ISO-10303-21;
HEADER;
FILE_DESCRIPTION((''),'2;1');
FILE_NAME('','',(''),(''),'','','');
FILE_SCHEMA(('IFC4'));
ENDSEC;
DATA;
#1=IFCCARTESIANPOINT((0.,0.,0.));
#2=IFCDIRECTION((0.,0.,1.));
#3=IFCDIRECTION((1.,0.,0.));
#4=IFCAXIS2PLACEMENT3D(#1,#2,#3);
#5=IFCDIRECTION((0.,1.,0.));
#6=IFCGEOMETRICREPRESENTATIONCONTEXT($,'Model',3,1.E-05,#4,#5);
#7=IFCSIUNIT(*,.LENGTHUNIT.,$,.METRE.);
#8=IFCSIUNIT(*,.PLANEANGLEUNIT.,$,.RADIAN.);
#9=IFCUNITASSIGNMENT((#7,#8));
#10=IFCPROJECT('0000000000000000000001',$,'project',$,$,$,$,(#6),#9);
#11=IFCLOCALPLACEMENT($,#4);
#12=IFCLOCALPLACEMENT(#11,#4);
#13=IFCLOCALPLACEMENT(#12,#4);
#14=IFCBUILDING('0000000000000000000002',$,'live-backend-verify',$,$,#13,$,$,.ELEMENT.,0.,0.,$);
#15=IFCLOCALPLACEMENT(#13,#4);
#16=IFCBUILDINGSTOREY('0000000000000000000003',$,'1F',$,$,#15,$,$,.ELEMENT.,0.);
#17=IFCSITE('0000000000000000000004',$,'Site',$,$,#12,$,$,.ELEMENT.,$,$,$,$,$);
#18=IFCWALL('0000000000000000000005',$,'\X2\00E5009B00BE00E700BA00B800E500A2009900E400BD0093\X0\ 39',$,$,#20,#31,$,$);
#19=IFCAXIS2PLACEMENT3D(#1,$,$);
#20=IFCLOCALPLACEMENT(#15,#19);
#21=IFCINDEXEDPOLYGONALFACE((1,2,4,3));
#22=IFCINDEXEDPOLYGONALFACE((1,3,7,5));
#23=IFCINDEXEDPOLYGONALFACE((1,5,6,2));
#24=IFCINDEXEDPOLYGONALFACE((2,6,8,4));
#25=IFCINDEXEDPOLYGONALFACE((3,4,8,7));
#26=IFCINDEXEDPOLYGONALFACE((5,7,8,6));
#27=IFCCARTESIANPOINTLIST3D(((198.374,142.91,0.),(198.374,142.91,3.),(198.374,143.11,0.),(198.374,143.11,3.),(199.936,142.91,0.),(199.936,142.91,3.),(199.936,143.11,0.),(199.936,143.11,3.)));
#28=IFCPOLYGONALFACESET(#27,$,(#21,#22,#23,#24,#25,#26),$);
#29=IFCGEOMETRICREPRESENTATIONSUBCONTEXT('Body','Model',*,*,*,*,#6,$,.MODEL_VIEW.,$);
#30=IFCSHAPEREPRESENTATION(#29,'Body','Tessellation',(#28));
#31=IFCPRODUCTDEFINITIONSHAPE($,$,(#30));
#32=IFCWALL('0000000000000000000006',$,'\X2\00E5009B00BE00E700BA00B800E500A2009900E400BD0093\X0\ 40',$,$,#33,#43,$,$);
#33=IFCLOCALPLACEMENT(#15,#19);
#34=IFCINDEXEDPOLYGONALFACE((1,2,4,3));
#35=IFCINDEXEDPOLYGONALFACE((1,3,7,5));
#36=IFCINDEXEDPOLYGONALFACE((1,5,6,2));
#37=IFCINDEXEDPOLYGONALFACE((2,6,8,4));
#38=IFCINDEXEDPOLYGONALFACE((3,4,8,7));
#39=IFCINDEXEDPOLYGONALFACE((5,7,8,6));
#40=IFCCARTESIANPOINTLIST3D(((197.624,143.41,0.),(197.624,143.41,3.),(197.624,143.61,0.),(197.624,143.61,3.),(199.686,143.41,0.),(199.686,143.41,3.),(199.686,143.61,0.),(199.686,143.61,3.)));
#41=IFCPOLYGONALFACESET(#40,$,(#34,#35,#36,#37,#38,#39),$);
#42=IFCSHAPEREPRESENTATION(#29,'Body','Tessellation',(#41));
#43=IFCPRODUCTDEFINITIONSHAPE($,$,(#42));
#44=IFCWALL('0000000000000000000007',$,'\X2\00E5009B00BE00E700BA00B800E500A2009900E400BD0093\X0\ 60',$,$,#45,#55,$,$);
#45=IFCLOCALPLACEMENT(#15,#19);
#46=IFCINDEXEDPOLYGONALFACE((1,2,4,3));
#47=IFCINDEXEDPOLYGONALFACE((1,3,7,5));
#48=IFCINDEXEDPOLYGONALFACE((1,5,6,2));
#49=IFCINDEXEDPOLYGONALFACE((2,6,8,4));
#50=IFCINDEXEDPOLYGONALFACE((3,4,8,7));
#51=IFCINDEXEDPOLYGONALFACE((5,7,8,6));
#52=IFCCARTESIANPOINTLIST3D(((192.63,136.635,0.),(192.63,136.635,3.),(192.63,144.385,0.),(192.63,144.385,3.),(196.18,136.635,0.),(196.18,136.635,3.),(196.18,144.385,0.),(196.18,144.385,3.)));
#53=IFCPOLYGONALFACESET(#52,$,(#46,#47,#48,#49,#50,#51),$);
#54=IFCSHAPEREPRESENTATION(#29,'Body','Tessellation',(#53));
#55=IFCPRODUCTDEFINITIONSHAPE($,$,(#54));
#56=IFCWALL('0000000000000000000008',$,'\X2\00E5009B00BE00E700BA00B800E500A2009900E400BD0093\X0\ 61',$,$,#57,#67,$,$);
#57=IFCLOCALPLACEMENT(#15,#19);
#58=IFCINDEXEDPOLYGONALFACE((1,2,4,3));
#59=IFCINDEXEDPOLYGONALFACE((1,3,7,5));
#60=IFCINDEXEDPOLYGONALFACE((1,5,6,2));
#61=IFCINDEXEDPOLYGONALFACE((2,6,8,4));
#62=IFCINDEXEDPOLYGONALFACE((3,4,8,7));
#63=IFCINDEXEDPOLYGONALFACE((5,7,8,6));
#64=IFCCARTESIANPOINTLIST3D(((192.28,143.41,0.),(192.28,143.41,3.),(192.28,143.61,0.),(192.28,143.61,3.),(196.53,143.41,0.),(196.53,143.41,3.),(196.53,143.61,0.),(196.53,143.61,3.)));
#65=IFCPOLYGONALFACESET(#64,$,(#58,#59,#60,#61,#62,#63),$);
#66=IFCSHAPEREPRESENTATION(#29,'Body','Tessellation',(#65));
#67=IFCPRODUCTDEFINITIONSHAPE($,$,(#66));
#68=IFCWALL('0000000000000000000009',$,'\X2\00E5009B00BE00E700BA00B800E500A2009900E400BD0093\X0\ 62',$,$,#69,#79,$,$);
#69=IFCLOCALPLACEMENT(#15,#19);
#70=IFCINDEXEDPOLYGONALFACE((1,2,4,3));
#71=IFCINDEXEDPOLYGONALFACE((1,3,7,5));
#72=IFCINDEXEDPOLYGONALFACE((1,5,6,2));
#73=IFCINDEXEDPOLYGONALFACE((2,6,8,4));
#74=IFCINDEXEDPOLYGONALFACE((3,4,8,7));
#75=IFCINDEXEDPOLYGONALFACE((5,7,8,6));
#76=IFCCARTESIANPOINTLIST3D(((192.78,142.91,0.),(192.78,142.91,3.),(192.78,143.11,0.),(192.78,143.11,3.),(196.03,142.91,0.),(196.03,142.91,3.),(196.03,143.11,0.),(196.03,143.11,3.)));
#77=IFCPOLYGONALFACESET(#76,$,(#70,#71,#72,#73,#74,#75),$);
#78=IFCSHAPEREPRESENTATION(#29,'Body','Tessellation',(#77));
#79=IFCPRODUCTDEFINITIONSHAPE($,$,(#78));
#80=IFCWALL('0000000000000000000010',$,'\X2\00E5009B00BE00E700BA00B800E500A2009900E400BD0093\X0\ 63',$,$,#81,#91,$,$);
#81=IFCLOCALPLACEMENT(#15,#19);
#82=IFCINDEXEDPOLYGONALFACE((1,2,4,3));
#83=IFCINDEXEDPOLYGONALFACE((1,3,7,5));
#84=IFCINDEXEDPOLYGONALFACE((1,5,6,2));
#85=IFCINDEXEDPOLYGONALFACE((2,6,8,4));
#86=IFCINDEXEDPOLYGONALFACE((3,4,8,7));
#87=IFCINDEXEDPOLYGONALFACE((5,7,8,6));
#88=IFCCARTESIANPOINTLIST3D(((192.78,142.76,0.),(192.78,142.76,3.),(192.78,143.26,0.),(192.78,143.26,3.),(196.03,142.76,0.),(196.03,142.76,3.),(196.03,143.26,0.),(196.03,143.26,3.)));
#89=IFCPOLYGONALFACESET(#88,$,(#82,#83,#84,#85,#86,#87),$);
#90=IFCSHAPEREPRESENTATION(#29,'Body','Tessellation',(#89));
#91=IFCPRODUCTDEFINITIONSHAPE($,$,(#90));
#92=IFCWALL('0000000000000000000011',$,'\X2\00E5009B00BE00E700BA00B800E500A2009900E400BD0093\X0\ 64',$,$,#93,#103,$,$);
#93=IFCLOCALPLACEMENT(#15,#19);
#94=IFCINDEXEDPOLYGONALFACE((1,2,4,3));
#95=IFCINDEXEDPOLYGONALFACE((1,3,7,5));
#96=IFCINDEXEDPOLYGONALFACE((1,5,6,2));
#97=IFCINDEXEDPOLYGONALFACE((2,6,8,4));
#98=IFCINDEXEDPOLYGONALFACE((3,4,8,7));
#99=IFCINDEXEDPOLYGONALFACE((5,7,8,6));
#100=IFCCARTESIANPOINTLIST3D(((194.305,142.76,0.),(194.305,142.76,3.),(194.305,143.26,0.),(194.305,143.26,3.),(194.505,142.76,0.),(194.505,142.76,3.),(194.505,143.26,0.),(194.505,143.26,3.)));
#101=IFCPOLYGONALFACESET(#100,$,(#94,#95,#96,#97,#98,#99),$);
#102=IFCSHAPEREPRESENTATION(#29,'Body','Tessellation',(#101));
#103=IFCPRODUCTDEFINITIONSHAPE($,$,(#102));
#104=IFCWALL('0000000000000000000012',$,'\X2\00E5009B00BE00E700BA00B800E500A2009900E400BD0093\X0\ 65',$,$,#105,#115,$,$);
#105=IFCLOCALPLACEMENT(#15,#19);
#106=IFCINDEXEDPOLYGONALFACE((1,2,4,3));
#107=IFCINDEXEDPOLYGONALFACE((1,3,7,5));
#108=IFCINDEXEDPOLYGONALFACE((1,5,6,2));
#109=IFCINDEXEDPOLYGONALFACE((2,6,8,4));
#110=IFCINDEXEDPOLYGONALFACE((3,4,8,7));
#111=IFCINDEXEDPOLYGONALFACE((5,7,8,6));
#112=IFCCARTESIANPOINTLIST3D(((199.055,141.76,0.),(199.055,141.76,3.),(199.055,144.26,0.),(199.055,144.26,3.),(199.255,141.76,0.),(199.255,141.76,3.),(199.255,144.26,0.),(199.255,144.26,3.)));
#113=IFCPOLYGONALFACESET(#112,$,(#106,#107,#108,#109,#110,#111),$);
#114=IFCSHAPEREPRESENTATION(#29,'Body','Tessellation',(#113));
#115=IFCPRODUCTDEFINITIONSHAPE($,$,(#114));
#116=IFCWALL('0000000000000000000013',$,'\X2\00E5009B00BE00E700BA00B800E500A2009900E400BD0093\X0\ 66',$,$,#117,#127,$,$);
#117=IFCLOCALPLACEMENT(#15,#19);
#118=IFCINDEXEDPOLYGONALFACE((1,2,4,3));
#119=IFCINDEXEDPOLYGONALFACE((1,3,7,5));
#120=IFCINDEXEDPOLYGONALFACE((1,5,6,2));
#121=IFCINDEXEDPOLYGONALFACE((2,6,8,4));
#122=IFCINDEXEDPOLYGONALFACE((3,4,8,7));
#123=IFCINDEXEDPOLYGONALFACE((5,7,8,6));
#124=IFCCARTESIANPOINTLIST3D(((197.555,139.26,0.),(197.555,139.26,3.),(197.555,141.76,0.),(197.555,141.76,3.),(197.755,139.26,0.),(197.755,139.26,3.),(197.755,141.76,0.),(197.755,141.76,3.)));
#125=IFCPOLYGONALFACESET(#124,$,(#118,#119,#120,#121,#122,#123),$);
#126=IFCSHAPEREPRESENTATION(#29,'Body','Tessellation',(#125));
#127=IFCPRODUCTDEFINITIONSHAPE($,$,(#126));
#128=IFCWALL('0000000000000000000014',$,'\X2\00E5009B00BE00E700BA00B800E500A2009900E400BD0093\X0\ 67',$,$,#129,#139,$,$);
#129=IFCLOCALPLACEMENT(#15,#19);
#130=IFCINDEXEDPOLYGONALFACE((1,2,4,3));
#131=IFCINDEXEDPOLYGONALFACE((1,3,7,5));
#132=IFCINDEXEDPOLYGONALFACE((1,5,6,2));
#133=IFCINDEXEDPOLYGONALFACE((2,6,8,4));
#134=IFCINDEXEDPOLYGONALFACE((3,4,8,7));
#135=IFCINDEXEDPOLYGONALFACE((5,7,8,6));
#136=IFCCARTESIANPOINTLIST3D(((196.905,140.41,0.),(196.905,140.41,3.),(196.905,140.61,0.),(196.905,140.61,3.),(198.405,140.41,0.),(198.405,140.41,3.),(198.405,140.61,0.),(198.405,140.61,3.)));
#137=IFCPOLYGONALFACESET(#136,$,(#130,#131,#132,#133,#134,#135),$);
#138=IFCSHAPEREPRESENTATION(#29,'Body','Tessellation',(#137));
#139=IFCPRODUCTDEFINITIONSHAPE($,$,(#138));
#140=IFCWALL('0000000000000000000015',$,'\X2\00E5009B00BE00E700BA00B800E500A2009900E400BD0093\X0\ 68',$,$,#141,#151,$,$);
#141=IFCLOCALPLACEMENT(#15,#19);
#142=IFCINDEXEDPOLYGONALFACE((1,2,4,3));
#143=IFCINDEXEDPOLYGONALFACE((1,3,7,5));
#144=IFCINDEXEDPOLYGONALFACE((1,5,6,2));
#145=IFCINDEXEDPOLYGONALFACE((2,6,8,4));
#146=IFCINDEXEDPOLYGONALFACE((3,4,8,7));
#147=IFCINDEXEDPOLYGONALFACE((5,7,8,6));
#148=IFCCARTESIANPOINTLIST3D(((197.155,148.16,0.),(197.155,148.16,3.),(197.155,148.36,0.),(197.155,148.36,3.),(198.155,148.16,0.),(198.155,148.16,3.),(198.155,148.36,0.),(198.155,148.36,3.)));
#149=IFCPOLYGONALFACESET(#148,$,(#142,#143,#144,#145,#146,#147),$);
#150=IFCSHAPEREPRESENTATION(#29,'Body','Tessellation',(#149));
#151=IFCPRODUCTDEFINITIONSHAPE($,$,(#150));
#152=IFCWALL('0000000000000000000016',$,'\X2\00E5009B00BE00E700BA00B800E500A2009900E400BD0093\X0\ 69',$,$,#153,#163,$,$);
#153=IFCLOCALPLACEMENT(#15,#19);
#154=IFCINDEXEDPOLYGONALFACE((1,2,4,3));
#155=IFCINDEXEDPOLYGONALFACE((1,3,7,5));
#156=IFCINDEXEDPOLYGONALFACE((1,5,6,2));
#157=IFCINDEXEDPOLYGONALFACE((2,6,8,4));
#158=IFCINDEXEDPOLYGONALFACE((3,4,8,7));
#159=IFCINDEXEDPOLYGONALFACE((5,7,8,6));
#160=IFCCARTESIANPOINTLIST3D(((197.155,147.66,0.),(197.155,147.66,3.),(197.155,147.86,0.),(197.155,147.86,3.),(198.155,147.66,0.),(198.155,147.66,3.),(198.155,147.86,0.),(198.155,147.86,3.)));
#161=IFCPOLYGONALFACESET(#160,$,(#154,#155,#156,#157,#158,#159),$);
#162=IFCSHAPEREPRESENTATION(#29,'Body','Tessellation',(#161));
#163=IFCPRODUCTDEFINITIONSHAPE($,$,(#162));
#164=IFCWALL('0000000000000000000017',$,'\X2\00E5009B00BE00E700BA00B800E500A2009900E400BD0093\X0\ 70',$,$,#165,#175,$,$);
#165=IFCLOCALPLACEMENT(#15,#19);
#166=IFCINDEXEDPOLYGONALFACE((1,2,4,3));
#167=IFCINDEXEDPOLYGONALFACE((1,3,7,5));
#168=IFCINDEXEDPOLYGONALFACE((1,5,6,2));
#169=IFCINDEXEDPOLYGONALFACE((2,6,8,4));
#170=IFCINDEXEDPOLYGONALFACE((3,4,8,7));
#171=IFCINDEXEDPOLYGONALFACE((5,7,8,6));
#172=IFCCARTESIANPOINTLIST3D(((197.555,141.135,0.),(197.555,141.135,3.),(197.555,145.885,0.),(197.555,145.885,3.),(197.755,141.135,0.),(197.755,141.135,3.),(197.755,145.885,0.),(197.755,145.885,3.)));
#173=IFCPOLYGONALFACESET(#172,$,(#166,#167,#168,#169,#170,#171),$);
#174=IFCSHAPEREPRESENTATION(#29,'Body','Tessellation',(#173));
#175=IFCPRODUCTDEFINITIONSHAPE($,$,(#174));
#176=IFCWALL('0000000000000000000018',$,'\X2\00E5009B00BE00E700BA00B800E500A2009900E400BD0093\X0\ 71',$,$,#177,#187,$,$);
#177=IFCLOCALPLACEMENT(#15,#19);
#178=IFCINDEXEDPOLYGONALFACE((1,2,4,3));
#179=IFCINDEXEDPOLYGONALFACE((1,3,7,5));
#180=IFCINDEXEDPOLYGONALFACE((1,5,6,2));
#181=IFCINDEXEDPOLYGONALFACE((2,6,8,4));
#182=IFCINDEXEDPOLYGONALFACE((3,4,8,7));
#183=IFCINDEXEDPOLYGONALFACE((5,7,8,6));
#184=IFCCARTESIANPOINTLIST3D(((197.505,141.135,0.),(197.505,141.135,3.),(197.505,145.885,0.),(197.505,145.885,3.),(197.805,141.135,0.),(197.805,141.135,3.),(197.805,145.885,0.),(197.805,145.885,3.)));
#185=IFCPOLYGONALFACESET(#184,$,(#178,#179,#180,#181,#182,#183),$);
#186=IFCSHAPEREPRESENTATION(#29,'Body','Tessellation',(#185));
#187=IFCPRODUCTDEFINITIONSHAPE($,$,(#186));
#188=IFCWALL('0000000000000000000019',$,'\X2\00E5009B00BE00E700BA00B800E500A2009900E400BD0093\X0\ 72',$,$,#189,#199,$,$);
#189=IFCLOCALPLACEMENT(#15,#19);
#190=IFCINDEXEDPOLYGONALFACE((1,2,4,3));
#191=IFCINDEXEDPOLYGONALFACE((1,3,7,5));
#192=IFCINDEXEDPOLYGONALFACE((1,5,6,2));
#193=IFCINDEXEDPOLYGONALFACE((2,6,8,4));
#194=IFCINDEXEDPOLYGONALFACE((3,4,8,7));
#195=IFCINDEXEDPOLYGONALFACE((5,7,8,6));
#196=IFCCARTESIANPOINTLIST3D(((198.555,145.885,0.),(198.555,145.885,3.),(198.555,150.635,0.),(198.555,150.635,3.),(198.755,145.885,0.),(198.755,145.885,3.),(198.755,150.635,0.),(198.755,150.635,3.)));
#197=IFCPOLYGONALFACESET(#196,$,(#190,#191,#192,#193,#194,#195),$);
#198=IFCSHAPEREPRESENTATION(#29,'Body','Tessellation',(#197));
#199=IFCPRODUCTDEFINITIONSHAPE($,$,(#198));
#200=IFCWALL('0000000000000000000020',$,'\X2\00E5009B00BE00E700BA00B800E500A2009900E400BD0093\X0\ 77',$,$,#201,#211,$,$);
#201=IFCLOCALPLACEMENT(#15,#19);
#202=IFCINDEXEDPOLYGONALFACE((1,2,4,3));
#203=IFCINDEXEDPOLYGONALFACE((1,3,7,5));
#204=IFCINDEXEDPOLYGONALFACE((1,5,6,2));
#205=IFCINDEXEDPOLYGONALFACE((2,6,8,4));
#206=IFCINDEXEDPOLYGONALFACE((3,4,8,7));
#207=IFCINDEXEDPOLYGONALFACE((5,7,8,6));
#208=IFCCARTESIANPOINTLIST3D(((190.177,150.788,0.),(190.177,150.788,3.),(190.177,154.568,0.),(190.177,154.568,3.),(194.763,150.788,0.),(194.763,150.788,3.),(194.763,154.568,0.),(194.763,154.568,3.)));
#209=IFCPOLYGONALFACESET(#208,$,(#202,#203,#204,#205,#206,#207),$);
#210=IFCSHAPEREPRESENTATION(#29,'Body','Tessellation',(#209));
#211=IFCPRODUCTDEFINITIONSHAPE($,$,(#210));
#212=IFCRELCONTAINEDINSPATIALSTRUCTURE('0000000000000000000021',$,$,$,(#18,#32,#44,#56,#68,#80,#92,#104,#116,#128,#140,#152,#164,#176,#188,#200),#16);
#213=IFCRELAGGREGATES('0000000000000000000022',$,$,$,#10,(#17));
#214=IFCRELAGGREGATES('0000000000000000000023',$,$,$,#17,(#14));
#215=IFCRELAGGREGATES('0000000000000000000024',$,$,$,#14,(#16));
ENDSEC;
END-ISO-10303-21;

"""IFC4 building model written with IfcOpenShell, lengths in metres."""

from ifc_helpers import new_model, si_unit, direction, frame, frame_2d, origin_with_axes, place, context, subcontext, project, spatial, rectangle, extrude, element, save


model = new_model("IFC4")

# Units and contexts
model_context = context("Model", 3, precision=1e-05, world=origin_with_axes(), true_north=direction((0.0, 1.0, 0.0)))
body_context = subcontext(model_context, "Body", "Model", "MODEL_VIEW")
ifc_project = project(units=[si_unit("LENGTHUNIT", "METRE"), si_unit("PLANEANGLEUNIT", "RADIAN")], contexts=[model_context])

# Site, building, storey
placement = place(None, origin_with_axes())
site_placement = place(placement, origin_with_axes())
site = spatial("IfcSite", under=ifc_project, at=site_placement, Name="Site", CompositionType="ELEMENT")
building_placement = place(site_placement, origin_with_axes())
building = spatial("IfcBuilding", under=site, at=building_placement, Name="live-backend-verify", CompositionType="ELEMENT", ElevationOfRefHeight=0.0, ElevationOfTerrain=0.0)
storey_placement = place(building_placement, origin_with_axes())
storey = spatial("IfcBuildingStorey", under=building, at=storey_placement, Name="1F", CompositionType="ELEMENT", Elevation=0.0)

# Walls
wall_1_placement = place(storey_placement, frame((199.155, 143.01, 0.0), z_axis=(0.0, 0.0, 1.0), x_axis=(1.0, 0.0, 0.0)))
element("IfcWall", 1, at=wall_1_placement, inside=storey, Name="å\u009b¾çº¸å¢\u0099ä½\u0093 39", context=body_context, shape_type="SweptSolid", body=[
    extrude(rectangle(XDim=1.562, YDim=0.2, at=frame_2d((0.0, 0.0), x_axis=(1.0, 0.0, 0.0))), frame((0.0, 0.0, 0.0), z_axis=(0.0, 0.0, 1.0)), (0.0, 0.0, 1.0), 3.0),
])
wall_2_placement = place(storey_placement, frame((198.655, 143.51, 0.0), z_axis=(0.0, 0.0, 1.0), x_axis=(1.0, 0.0, 0.0)))
element("IfcWall", 2, at=wall_2_placement, inside=storey, Name="å\u009b¾çº¸å¢\u0099ä½\u0093 40", context=body_context, shape_type="SweptSolid", body=[
    extrude(rectangle(XDim=2.062, YDim=0.2, at=frame_2d((0.0, 0.0), x_axis=(1.0, 0.0, 0.0))), frame((0.0, 0.0, 0.0), z_axis=(0.0, 0.0, 1.0)), (0.0, 0.0, 1.0), 3.0),
])
wall_3_placement = place(storey_placement, frame((194.405, 140.51, 0.0), z_axis=(0.0, 0.0, 1.0), x_axis=(1.0, 0.0, 0.0)))
element("IfcWall", 3, at=wall_3_placement, inside=storey, Name="å\u009b¾çº¸å¢\u0099ä½\u0093 60", context=body_context, shape_type="SweptSolid", body=[
    extrude(rectangle(XDim=3.55, YDim=7.75, at=frame_2d((0.0, 0.0), x_axis=(1.0, 0.0, 0.0))), frame((0.0, 0.0, 0.0), z_axis=(0.0, 0.0, 1.0)), (0.0, 0.0, 1.0), 3.0),
])
wall_4_placement = place(storey_placement, frame((194.405, 143.51, 0.0), z_axis=(0.0, 0.0, 1.0), x_axis=(1.0, 0.0, 0.0)))
element("IfcWall", 4, at=wall_4_placement, inside=storey, Name="å\u009b¾çº¸å¢\u0099ä½\u0093 61", context=body_context, shape_type="SweptSolid", body=[
    extrude(rectangle(XDim=4.25, YDim=0.2, at=frame_2d((0.0, 0.0), x_axis=(1.0, 0.0, 0.0))), frame((0.0, 0.0, 0.0), z_axis=(0.0, 0.0, 1.0)), (0.0, 0.0, 1.0), 3.0),
])
wall_5_placement = place(storey_placement, frame((194.405, 143.01, 0.0), z_axis=(0.0, 0.0, 1.0), x_axis=(1.0, 0.0, 0.0)))
element("IfcWall", 5, at=wall_5_placement, inside=storey, Name="å\u009b¾çº¸å¢\u0099ä½\u0093 62", context=body_context, shape_type="SweptSolid", body=[
    extrude(rectangle(XDim=3.25, YDim=0.2, at=frame_2d((0.0, 0.0), x_axis=(1.0, 0.0, 0.0))), frame((0.0, 0.0, 0.0), z_axis=(0.0, 0.0, 1.0)), (0.0, 0.0, 1.0), 3.0),
])
wall_6_placement = place(storey_placement, frame((194.405, 143.01, 0.0), z_axis=(0.0, 0.0, 1.0), x_axis=(1.0, 0.0, 0.0)))
element("IfcWall", 6, at=wall_6_placement, inside=storey, Name="å\u009b¾çº¸å¢\u0099ä½\u0093 63", context=body_context, shape_type="SweptSolid", body=[
    extrude(rectangle(XDim=3.25, YDim=0.5, at=frame_2d((0.0, 0.0), x_axis=(1.0, 0.0, 0.0))), frame((0.0, 0.0, 0.0), z_axis=(0.0, 0.0, 1.0)), (0.0, 0.0, 1.0), 3.0),
])
wall_7_placement = place(storey_placement, frame((194.405, 143.01, 0.0), z_axis=(0.0, 0.0, 1.0), x_axis=(0.0, 1.0, 0.0)))
element("IfcWall", 7, at=wall_7_placement, inside=storey, Name="å\u009b¾çº¸å¢\u0099ä½\u0093 64", context=body_context, shape_type="SweptSolid", body=[
    extrude(rectangle(XDim=0.5, YDim=0.2, at=frame_2d((0.0, 0.0), x_axis=(1.0, 0.0, 0.0))), frame((0.0, 0.0, 0.0), z_axis=(0.0, 0.0, 1.0)), (0.0, 0.0, 1.0), 3.0),
])
for number, where, z_axis, x_axis, name in (
    (8, (199.155, 143.01, 0.0), (0.0, 0.0, 1.0), (0.0, -1.0, 0.0), "å\u009b¾çº¸å¢\u0099ä½\u0093 65"),
    (9, (197.655, 140.51, 0.0), (0.0, 0.0, 1.0), (0.0, 1.0, 0.0), "å\u009b¾çº¸å¢\u0099ä½\u0093 66"),
):
    element("IfcWall", number, at=place(storey_placement, frame(where, z_axis=z_axis, x_axis=x_axis)), inside=storey, Name=name, context=body_context, shape_type="SweptSolid", body=[
        extrude(rectangle(XDim=2.5, YDim=0.2, at=frame_2d((0.0, 0.0), x_axis=(1.0, 0.0, 0.0))), frame((0.0, 0.0, 0.0), z_axis=(0.0, 0.0, 1.0)), (0.0, 0.0, 1.0), 3.0),
    ])
wall_8_placement = place(storey_placement, frame((197.655, 140.51, 0.0), z_axis=(0.0, 0.0, 1.0), x_axis=(1.0, 0.0, 0.0)))
element("IfcWall", 10, at=wall_8_placement, inside=storey, Name="å\u009b¾çº¸å¢\u0099ä½\u0093 67", context=body_context, shape_type="SweptSolid", body=[
    extrude(rectangle(XDim=1.5, YDim=0.2, at=frame_2d((0.0, 0.0), x_axis=(1.0, 0.0, 0.0))), frame((0.0, 0.0, 0.0), z_axis=(0.0, 0.0, 1.0)), (0.0, 0.0, 1.0), 3.0),
])
for number, where, z_axis, x_axis, name in (
    (11, (197.655, 148.26, 0.0), (0.0, 0.0, 1.0), (1.0, 0.0, 0.0), "å\u009b¾çº¸å¢\u0099ä½\u0093 68"),
    (12, (197.655, 147.76, 0.0), (0.0, 0.0, 1.0), (1.0, 0.0, 0.0), "å\u009b¾çº¸å¢\u0099ä½\u0093 69"),
):
    element("IfcWall", number, at=place(storey_placement, frame(where, z_axis=z_axis, x_axis=x_axis)), inside=storey, Name=name, context=body_context, shape_type="SweptSolid", body=[
        extrude(rectangle(XDim=1.0, YDim=0.2, at=frame_2d((0.0, 0.0), x_axis=(1.0, 0.0, 0.0))), frame((0.0, 0.0, 0.0), z_axis=(0.0, 0.0, 1.0)), (0.0, 0.0, 1.0), 3.0),
    ])
wall_9_placement = place(storey_placement, frame((197.655, 143.51, 0.0), z_axis=(0.0, 0.0, 1.0), x_axis=(0.0, 1.0, 0.0)))
element("IfcWall", 13, at=wall_9_placement, inside=storey, Name="å\u009b¾çº¸å¢\u0099ä½\u0093 70", context=body_context, shape_type="SweptSolid", body=[
    extrude(rectangle(XDim=4.75, YDim=0.2, at=frame_2d((0.0, 0.0), x_axis=(1.0, 0.0, 0.0))), frame((0.0, 0.0, 0.0), z_axis=(0.0, 0.0, 1.0)), (0.0, 0.0, 1.0), 3.0),
])
wall_10_placement = place(storey_placement, frame((197.655, 143.51, 0.0), z_axis=(0.0, 0.0, 1.0), x_axis=(1.0, 0.0, 0.0)))
element("IfcWall", 14, at=wall_10_placement, inside=storey, Name="å\u009b¾çº¸å¢\u0099ä½\u0093 71", context=body_context, shape_type="SweptSolid", body=[
    extrude(rectangle(XDim=0.3, YDim=4.75, at=frame_2d((0.0, 0.0), x_axis=(1.0, 0.0, 0.0))), frame((0.0, 0.0, 0.0), z_axis=(0.0, 0.0, 1.0)), (0.0, 0.0, 1.0), 3.0),
])
wall_11_placement = place(storey_placement, frame((198.655, 148.26, 0.0), z_axis=(0.0, 0.0, 1.0), x_axis=(0.0, -1.0, 0.0)))
element("IfcWall", 15, at=wall_11_placement, inside=storey, Name="å\u009b¾çº¸å¢\u0099ä½\u0093 72", context=body_context, shape_type="SweptSolid", body=[
    extrude(rectangle(XDim=4.75, YDim=0.2, at=frame_2d((0.0, 0.0), x_axis=(1.0, 0.0, 0.0))), frame((0.0, 0.0, 0.0), z_axis=(0.0, 0.0, 1.0)), (0.0, 0.0, 1.0), 3.0),
])
wall_12_placement = place(storey_placement, frame((192.47, 152.678, 0.0), z_axis=(0.0, 0.0, 1.0), x_axis=(1.0, 0.0, 0.0)))
element("IfcWall", 16, at=wall_12_placement, inside=storey, Name="å\u009b¾çº¸å¢\u0099ä½\u0093 77", context=body_context, shape_type="SweptSolid", body=[
    extrude(rectangle(XDim=4.586, YDim=3.78, at=frame_2d((0.0, 0.0), x_axis=(1.0, 0.0, 0.0))), frame((0.0, 0.0, 0.0), z_axis=(0.0, 0.0, 1.0)), (0.0, 0.0, 1.0), 3.0),
])

save(model, "model.ifc")
